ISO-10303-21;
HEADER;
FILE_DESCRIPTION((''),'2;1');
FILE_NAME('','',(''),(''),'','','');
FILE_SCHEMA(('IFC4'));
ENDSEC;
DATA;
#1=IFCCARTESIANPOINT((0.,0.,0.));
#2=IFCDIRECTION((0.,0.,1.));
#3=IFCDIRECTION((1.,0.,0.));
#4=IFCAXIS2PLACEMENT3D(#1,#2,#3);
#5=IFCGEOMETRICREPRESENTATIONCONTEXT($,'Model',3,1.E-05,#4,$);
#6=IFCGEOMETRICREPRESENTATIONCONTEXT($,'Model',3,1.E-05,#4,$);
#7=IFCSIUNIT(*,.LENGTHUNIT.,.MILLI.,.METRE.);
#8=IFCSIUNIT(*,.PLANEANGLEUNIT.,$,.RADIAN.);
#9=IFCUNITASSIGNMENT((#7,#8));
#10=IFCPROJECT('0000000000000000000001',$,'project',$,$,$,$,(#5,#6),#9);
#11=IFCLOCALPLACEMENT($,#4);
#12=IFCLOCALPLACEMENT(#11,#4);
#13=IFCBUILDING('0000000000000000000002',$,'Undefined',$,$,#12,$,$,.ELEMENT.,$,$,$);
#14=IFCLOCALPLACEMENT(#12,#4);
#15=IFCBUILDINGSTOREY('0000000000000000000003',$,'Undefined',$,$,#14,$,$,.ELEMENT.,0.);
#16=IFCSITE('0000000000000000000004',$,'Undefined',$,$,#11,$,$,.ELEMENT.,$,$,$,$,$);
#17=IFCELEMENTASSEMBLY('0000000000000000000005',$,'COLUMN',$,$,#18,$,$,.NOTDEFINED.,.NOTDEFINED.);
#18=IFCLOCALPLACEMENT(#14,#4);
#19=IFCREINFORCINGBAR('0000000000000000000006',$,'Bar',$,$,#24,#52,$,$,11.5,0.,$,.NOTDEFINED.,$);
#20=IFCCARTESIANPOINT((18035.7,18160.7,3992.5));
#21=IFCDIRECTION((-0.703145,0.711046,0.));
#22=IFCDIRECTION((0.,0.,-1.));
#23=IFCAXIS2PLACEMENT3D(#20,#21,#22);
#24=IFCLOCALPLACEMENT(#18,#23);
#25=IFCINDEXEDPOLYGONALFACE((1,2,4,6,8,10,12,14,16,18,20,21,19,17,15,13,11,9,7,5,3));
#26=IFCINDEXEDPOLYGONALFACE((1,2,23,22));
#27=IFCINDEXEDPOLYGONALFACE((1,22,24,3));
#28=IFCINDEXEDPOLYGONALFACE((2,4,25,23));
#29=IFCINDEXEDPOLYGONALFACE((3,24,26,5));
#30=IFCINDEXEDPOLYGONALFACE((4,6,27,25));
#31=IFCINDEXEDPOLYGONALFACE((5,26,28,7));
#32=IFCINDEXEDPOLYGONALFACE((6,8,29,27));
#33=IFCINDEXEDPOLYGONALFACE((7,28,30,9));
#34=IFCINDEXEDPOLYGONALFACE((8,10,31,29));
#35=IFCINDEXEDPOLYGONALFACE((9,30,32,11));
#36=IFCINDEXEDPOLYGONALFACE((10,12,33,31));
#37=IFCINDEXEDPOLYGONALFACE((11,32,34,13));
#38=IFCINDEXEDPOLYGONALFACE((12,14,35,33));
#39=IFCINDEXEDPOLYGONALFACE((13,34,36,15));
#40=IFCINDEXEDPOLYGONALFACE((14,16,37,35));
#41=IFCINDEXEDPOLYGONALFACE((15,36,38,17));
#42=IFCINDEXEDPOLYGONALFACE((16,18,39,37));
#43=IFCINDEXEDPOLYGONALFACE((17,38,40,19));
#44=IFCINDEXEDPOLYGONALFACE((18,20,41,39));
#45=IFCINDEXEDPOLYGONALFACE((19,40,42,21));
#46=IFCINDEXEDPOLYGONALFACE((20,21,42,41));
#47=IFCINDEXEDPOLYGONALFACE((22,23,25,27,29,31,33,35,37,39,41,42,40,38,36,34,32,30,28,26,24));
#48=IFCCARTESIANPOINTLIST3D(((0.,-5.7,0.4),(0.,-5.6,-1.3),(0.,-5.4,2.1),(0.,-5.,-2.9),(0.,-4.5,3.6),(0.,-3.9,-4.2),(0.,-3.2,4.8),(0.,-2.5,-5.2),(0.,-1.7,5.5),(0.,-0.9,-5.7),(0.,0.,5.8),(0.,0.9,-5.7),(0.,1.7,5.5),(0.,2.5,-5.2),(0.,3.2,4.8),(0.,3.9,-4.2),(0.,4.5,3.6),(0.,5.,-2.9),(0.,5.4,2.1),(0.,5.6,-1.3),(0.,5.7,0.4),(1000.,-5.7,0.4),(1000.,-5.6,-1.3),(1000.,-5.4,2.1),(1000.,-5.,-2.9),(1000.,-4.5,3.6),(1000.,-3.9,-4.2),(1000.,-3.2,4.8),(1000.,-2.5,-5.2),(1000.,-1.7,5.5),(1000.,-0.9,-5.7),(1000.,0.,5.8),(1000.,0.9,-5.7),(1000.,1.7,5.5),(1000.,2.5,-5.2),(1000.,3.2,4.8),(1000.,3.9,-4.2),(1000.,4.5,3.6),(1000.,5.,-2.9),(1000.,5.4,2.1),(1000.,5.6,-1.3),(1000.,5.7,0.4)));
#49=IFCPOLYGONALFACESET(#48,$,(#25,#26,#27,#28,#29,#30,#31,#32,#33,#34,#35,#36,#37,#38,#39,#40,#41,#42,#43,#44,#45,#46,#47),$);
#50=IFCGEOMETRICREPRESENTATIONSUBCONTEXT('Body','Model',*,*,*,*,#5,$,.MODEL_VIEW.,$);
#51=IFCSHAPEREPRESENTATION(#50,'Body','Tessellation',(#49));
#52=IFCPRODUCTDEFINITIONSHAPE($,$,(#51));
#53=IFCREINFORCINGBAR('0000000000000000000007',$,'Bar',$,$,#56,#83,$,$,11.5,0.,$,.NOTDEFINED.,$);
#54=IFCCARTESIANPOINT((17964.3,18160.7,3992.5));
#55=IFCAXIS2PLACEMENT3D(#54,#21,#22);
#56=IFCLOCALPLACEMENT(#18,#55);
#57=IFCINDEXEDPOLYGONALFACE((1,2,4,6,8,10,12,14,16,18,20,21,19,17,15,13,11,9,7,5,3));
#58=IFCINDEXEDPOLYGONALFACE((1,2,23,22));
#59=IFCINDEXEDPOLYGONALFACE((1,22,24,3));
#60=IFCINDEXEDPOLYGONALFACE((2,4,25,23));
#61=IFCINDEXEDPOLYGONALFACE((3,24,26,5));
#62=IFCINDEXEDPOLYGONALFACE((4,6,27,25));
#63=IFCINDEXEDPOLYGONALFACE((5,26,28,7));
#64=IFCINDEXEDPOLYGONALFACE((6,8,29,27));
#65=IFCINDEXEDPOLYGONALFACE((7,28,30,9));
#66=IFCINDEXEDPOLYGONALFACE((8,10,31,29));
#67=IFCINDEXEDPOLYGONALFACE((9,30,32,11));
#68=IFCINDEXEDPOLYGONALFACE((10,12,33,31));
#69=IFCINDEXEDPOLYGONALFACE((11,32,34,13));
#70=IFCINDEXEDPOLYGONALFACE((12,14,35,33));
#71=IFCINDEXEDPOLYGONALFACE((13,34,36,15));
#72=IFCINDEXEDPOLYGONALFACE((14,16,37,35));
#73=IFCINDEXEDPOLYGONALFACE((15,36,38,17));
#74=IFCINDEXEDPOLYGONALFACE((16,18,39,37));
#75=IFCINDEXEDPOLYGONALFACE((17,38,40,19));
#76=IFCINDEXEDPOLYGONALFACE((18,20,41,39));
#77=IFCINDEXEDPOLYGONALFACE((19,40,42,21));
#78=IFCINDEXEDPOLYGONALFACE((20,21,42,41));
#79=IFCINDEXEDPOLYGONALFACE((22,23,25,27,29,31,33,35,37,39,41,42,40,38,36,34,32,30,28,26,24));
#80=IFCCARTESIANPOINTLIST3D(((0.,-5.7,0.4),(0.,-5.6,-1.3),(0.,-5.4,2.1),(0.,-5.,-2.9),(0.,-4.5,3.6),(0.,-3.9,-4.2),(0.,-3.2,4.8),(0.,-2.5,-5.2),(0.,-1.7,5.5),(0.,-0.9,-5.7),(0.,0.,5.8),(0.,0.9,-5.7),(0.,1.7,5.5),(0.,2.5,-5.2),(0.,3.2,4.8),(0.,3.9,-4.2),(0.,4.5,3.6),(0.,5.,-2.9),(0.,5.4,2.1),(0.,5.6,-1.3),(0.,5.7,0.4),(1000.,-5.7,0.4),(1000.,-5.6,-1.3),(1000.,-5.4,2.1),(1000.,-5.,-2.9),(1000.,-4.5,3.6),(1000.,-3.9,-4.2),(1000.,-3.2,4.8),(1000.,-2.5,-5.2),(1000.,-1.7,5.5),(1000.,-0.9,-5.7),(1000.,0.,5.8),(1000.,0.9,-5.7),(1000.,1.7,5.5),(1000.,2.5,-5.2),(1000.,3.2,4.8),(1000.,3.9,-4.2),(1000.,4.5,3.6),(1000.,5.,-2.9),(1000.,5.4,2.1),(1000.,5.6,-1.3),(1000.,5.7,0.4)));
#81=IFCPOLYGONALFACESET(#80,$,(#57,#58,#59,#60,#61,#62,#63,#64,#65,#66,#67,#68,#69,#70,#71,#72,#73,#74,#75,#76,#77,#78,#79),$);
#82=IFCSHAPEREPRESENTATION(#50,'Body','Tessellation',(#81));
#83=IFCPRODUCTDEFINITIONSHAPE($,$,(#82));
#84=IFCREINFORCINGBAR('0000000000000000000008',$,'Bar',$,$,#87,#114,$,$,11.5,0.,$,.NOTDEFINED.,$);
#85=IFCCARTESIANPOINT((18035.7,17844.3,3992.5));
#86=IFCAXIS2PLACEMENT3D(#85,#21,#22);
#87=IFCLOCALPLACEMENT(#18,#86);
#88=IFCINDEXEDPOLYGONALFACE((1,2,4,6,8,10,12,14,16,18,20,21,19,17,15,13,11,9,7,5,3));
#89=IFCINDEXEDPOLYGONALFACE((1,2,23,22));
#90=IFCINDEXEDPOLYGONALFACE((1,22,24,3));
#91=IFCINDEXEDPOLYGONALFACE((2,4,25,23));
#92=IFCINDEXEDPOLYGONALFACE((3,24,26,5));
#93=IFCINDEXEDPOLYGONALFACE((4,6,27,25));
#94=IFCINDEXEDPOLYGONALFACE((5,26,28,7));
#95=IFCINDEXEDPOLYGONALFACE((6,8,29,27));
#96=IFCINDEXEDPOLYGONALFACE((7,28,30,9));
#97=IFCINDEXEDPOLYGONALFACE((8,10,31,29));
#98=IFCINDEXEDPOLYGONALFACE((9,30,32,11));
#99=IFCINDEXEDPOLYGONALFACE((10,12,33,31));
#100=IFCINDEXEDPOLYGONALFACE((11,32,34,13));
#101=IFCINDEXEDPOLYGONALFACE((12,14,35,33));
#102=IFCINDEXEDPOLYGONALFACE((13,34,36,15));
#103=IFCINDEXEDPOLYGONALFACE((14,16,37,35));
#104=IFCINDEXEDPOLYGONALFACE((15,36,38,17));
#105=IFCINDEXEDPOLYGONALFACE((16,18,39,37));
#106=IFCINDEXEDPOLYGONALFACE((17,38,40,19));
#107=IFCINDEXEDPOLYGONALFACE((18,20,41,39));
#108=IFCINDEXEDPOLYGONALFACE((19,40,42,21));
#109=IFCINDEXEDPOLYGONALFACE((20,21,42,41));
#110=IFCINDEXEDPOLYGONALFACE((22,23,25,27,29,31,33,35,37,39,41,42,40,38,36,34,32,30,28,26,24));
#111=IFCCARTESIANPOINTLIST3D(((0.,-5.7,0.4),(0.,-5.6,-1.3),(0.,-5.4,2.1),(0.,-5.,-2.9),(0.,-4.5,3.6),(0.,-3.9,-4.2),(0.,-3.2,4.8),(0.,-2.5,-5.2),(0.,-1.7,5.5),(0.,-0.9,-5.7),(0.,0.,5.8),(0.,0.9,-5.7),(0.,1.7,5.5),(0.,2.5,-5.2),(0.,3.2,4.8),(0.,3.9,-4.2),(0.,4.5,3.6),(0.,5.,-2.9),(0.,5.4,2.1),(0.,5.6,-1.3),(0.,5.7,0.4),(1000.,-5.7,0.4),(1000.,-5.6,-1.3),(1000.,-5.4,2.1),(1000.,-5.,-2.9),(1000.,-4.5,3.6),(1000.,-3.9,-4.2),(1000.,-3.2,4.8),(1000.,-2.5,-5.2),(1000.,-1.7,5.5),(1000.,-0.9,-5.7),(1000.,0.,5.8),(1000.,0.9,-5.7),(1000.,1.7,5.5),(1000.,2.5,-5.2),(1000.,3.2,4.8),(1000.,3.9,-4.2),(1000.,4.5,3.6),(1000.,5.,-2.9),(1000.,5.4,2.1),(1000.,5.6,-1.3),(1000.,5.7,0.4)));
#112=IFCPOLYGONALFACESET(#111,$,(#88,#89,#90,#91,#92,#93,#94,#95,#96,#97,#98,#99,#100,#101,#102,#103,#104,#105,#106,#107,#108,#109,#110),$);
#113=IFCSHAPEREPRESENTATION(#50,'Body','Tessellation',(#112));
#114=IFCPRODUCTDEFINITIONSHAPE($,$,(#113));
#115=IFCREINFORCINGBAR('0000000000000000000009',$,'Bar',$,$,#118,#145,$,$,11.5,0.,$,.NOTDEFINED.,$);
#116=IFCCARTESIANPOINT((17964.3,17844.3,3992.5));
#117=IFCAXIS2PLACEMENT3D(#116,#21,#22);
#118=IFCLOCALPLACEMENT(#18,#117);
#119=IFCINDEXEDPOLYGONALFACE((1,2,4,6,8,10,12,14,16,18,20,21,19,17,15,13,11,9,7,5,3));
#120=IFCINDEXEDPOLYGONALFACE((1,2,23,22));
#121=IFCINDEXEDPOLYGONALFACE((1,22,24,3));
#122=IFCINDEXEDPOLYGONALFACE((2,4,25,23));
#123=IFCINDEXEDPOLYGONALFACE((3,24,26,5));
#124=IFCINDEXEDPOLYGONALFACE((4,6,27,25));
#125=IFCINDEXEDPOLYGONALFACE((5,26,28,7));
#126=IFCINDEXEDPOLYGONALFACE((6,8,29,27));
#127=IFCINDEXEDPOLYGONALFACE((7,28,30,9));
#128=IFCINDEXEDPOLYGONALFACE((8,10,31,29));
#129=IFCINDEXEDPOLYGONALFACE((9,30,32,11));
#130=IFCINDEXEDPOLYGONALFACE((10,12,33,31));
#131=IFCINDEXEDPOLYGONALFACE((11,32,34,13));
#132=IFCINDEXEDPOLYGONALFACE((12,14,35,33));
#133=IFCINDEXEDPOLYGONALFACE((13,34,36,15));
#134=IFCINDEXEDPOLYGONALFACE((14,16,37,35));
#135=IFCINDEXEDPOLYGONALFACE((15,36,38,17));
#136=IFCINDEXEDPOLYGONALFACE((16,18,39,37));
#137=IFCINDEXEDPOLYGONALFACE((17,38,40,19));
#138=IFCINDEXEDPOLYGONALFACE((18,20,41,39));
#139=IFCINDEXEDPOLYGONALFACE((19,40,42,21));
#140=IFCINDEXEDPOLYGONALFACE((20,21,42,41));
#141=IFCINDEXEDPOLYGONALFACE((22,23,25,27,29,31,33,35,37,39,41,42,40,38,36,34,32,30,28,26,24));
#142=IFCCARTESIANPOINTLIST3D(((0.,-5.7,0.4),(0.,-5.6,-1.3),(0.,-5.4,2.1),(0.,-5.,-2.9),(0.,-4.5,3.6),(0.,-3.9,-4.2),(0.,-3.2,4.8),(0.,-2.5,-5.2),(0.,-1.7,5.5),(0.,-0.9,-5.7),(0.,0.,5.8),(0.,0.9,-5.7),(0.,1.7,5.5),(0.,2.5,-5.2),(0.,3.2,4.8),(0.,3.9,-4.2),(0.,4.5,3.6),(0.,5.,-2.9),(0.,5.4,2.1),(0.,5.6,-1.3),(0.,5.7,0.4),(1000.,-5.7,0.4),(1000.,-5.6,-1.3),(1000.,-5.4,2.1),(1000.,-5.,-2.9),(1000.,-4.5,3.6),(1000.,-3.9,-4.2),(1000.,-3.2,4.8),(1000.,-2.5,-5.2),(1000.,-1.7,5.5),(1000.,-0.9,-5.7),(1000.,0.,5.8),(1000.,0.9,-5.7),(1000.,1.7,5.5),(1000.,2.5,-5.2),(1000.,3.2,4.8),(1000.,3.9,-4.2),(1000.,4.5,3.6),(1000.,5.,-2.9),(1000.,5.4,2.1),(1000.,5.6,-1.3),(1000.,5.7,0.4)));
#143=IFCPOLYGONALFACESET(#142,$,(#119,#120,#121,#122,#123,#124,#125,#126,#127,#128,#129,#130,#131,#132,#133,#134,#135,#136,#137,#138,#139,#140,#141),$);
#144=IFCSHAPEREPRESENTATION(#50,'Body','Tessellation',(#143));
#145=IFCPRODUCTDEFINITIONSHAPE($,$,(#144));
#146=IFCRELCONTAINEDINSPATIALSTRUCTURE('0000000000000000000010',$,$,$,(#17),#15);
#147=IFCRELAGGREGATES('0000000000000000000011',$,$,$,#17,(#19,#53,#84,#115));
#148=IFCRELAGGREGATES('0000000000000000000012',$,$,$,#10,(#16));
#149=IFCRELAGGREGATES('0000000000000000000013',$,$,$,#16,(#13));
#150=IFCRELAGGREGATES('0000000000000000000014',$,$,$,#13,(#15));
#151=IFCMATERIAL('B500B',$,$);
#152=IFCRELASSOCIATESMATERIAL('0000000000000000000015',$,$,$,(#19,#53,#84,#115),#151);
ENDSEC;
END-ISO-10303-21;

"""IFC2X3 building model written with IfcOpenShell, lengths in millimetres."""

from ifc_helpers import new_model, entity, si_unit, frame, origin_with_axes, place, context, subcontext, project, spatial, source, transform, mapped, material, element, aggregate, save


model = new_model("IFC2X3")

# Units and contexts
model_context_1 = context("Model", 3, precision=1e-05, world=origin_with_axes())
model_context_2 = context("Model", 3, precision=1e-05, world=origin_with_axes())
body_context = subcontext(model_context_1, "Body", "Model", "MODEL_VIEW")
ifc_project = project(units=[si_unit("LENGTHUNIT", "METRE", prefix="MILLI"), si_unit("PLANEANGLEUNIT", "RADIAN")], contexts=[model_context_1, model_context_2])

# Site, building, storey
site_placement = place(None, origin_with_axes())
site = spatial("IfcSite", under=ifc_project, at=site_placement, Name="Undefined", CompositionType="ELEMENT")
building_placement = place(site_placement, origin_with_axes())
building = spatial("IfcBuilding", under=site, at=building_placement, Name="Undefined", CompositionType="ELEMENT")
storey_placement = place(building_placement, origin_with_axes())
storey = spatial("IfcBuildingStorey", under=building, at=storey_placement, Name="Undefined", CompositionType="ELEMENT", Elevation=0.0)

# Element assembly
assembly_1_placement = place(storey_placement, origin_with_axes())
assembly_1 = element("IfcElementAssembly", 1, at=assembly_1_placement, inside=storey, Name="COLUMN", AssemblyPlace="NOTDEFINED", PredefinedType="NOTDEFINED")

# Shared definitions
ifc_material_1 = material(Name="B500B")

# Reinforcing bars
shared_shape_1 = source(origin_with_axes(), body_context, "Body", "AdvancedSweptSolid", [
    entity("IfcSweptDiskSolid", entity("IfcTrimmedCurve", entity("IfcLine", entity("IfcCartesianPoint", [0.0, 0.0, 0.0]), entity("IfcVector", entity("IfcDirection", [1.0, 0.0, 0.0]), 1.0)), [entity("IfcParameterValue", 0.0)], [entity("IfcParameterValue", 1000.0)], True, "PARAMETER"), 5.8, None, 0.0, 1000.0),
])
reinforcing_bar_1_placement = place(assembly_1_placement, frame((18035.7, 18160.7, 3992.5), z_axis=(-0.703145, 0.711046, 0.0), x_axis=(0.0, 0.0, -1.0)))
reinforcing_bar_1 = element("IfcReinforcingBar", 2, at=reinforcing_bar_1_placement, material=ifc_material_1, Name="Bar", BarRole="NOTDEFINED", CrossSectionArea=0.0, NominalDiameter=11.5, context=body_context, shape_type="MappedRepresentation", body=[
    mapped(shared_shape_1, transform((0.0, 0.0, 0.0))),
])
shared_shape_2 = source(origin_with_axes(), body_context, "Body", "AdvancedSweptSolid", [
    entity("IfcSweptDiskSolid", entity("IfcTrimmedCurve", entity("IfcLine", entity("IfcCartesianPoint", [0.0, 0.0, 0.0]), entity("IfcVector", entity("IfcDirection", [1.0, 0.0, 0.0]), 1.0)), [entity("IfcParameterValue", 0.0)], [entity("IfcParameterValue", 1000.0)], True, "PARAMETER"), 5.8, None, 0.0, 1000.0),
])
reinforcing_bar_2_placement = place(assembly_1_placement, frame((17964.3, 18160.7, 3992.5), z_axis=(-0.703145, 0.711046, 0.0), x_axis=(0.0, 0.0, -1.0)))
reinforcing_bar_2 = element("IfcReinforcingBar", 3, at=reinforcing_bar_2_placement, material=ifc_material_1, Name="Bar", BarRole="NOTDEFINED", CrossSectionArea=0.0, NominalDiameter=11.5, context=body_context, shape_type="MappedRepresentation", body=[
    mapped(shared_shape_2, transform((0.0, 0.0, 0.0))),
])
shared_shape_3 = source(origin_with_axes(), body_context, "Body", "AdvancedSweptSolid", [
    entity("IfcSweptDiskSolid", entity("IfcTrimmedCurve", entity("IfcLine", entity("IfcCartesianPoint", [0.0, 0.0, 0.0]), entity("IfcVector", entity("IfcDirection", [1.0, 0.0, 0.0]), 1.0)), [entity("IfcParameterValue", 0.0)], [entity("IfcParameterValue", 1000.0)], True, "PARAMETER"), 5.8, None, 0.0, 1000.0),
])
reinforcing_bar_3_placement = place(assembly_1_placement, frame((18035.7, 17844.3, 3992.5), z_axis=(-0.703145, 0.711046, 0.0), x_axis=(0.0, 0.0, -1.0)))
reinforcing_bar_3 = element("IfcReinforcingBar", 4, at=reinforcing_bar_3_placement, material=ifc_material_1, Name="Bar", BarRole="NOTDEFINED", CrossSectionArea=0.0, NominalDiameter=11.5, context=body_context, shape_type="MappedRepresentation", body=[
    mapped(shared_shape_3, transform((0.0, 0.0, 0.0))),
])
shared_shape_4 = source(origin_with_axes(), body_context, "Body", "AdvancedSweptSolid", [
    entity("IfcSweptDiskSolid", entity("IfcTrimmedCurve", entity("IfcLine", entity("IfcCartesianPoint", [0.0, 0.0, 0.0]), entity("IfcVector", entity("IfcDirection", [1.0, 0.0, 0.0]), 1.0)), [entity("IfcParameterValue", 0.0)], [entity("IfcParameterValue", 1000.0)], True, "PARAMETER"), 5.8, None, 0.0, 1000.0),
])
reinforcing_bar_4_placement = place(assembly_1_placement, frame((17964.3, 17844.3, 3992.5), z_axis=(-0.703145, 0.711046, 0.0), x_axis=(0.0, 0.0, -1.0)))
reinforcing_bar_4 = element("IfcReinforcingBar", 5, at=reinforcing_bar_4_placement, material=ifc_material_1, Name="Bar", BarRole="NOTDEFINED", CrossSectionArea=0.0, NominalDiameter=11.5, context=body_context, shape_type="MappedRepresentation", body=[
    mapped(shared_shape_4, transform((0.0, 0.0, 0.0))),
])
aggregate(assembly_1, [reinforcing_bar_1, reinforcing_bar_2, reinforcing_bar_3, reinforcing_bar_4])

save(model, "model.ifc")
